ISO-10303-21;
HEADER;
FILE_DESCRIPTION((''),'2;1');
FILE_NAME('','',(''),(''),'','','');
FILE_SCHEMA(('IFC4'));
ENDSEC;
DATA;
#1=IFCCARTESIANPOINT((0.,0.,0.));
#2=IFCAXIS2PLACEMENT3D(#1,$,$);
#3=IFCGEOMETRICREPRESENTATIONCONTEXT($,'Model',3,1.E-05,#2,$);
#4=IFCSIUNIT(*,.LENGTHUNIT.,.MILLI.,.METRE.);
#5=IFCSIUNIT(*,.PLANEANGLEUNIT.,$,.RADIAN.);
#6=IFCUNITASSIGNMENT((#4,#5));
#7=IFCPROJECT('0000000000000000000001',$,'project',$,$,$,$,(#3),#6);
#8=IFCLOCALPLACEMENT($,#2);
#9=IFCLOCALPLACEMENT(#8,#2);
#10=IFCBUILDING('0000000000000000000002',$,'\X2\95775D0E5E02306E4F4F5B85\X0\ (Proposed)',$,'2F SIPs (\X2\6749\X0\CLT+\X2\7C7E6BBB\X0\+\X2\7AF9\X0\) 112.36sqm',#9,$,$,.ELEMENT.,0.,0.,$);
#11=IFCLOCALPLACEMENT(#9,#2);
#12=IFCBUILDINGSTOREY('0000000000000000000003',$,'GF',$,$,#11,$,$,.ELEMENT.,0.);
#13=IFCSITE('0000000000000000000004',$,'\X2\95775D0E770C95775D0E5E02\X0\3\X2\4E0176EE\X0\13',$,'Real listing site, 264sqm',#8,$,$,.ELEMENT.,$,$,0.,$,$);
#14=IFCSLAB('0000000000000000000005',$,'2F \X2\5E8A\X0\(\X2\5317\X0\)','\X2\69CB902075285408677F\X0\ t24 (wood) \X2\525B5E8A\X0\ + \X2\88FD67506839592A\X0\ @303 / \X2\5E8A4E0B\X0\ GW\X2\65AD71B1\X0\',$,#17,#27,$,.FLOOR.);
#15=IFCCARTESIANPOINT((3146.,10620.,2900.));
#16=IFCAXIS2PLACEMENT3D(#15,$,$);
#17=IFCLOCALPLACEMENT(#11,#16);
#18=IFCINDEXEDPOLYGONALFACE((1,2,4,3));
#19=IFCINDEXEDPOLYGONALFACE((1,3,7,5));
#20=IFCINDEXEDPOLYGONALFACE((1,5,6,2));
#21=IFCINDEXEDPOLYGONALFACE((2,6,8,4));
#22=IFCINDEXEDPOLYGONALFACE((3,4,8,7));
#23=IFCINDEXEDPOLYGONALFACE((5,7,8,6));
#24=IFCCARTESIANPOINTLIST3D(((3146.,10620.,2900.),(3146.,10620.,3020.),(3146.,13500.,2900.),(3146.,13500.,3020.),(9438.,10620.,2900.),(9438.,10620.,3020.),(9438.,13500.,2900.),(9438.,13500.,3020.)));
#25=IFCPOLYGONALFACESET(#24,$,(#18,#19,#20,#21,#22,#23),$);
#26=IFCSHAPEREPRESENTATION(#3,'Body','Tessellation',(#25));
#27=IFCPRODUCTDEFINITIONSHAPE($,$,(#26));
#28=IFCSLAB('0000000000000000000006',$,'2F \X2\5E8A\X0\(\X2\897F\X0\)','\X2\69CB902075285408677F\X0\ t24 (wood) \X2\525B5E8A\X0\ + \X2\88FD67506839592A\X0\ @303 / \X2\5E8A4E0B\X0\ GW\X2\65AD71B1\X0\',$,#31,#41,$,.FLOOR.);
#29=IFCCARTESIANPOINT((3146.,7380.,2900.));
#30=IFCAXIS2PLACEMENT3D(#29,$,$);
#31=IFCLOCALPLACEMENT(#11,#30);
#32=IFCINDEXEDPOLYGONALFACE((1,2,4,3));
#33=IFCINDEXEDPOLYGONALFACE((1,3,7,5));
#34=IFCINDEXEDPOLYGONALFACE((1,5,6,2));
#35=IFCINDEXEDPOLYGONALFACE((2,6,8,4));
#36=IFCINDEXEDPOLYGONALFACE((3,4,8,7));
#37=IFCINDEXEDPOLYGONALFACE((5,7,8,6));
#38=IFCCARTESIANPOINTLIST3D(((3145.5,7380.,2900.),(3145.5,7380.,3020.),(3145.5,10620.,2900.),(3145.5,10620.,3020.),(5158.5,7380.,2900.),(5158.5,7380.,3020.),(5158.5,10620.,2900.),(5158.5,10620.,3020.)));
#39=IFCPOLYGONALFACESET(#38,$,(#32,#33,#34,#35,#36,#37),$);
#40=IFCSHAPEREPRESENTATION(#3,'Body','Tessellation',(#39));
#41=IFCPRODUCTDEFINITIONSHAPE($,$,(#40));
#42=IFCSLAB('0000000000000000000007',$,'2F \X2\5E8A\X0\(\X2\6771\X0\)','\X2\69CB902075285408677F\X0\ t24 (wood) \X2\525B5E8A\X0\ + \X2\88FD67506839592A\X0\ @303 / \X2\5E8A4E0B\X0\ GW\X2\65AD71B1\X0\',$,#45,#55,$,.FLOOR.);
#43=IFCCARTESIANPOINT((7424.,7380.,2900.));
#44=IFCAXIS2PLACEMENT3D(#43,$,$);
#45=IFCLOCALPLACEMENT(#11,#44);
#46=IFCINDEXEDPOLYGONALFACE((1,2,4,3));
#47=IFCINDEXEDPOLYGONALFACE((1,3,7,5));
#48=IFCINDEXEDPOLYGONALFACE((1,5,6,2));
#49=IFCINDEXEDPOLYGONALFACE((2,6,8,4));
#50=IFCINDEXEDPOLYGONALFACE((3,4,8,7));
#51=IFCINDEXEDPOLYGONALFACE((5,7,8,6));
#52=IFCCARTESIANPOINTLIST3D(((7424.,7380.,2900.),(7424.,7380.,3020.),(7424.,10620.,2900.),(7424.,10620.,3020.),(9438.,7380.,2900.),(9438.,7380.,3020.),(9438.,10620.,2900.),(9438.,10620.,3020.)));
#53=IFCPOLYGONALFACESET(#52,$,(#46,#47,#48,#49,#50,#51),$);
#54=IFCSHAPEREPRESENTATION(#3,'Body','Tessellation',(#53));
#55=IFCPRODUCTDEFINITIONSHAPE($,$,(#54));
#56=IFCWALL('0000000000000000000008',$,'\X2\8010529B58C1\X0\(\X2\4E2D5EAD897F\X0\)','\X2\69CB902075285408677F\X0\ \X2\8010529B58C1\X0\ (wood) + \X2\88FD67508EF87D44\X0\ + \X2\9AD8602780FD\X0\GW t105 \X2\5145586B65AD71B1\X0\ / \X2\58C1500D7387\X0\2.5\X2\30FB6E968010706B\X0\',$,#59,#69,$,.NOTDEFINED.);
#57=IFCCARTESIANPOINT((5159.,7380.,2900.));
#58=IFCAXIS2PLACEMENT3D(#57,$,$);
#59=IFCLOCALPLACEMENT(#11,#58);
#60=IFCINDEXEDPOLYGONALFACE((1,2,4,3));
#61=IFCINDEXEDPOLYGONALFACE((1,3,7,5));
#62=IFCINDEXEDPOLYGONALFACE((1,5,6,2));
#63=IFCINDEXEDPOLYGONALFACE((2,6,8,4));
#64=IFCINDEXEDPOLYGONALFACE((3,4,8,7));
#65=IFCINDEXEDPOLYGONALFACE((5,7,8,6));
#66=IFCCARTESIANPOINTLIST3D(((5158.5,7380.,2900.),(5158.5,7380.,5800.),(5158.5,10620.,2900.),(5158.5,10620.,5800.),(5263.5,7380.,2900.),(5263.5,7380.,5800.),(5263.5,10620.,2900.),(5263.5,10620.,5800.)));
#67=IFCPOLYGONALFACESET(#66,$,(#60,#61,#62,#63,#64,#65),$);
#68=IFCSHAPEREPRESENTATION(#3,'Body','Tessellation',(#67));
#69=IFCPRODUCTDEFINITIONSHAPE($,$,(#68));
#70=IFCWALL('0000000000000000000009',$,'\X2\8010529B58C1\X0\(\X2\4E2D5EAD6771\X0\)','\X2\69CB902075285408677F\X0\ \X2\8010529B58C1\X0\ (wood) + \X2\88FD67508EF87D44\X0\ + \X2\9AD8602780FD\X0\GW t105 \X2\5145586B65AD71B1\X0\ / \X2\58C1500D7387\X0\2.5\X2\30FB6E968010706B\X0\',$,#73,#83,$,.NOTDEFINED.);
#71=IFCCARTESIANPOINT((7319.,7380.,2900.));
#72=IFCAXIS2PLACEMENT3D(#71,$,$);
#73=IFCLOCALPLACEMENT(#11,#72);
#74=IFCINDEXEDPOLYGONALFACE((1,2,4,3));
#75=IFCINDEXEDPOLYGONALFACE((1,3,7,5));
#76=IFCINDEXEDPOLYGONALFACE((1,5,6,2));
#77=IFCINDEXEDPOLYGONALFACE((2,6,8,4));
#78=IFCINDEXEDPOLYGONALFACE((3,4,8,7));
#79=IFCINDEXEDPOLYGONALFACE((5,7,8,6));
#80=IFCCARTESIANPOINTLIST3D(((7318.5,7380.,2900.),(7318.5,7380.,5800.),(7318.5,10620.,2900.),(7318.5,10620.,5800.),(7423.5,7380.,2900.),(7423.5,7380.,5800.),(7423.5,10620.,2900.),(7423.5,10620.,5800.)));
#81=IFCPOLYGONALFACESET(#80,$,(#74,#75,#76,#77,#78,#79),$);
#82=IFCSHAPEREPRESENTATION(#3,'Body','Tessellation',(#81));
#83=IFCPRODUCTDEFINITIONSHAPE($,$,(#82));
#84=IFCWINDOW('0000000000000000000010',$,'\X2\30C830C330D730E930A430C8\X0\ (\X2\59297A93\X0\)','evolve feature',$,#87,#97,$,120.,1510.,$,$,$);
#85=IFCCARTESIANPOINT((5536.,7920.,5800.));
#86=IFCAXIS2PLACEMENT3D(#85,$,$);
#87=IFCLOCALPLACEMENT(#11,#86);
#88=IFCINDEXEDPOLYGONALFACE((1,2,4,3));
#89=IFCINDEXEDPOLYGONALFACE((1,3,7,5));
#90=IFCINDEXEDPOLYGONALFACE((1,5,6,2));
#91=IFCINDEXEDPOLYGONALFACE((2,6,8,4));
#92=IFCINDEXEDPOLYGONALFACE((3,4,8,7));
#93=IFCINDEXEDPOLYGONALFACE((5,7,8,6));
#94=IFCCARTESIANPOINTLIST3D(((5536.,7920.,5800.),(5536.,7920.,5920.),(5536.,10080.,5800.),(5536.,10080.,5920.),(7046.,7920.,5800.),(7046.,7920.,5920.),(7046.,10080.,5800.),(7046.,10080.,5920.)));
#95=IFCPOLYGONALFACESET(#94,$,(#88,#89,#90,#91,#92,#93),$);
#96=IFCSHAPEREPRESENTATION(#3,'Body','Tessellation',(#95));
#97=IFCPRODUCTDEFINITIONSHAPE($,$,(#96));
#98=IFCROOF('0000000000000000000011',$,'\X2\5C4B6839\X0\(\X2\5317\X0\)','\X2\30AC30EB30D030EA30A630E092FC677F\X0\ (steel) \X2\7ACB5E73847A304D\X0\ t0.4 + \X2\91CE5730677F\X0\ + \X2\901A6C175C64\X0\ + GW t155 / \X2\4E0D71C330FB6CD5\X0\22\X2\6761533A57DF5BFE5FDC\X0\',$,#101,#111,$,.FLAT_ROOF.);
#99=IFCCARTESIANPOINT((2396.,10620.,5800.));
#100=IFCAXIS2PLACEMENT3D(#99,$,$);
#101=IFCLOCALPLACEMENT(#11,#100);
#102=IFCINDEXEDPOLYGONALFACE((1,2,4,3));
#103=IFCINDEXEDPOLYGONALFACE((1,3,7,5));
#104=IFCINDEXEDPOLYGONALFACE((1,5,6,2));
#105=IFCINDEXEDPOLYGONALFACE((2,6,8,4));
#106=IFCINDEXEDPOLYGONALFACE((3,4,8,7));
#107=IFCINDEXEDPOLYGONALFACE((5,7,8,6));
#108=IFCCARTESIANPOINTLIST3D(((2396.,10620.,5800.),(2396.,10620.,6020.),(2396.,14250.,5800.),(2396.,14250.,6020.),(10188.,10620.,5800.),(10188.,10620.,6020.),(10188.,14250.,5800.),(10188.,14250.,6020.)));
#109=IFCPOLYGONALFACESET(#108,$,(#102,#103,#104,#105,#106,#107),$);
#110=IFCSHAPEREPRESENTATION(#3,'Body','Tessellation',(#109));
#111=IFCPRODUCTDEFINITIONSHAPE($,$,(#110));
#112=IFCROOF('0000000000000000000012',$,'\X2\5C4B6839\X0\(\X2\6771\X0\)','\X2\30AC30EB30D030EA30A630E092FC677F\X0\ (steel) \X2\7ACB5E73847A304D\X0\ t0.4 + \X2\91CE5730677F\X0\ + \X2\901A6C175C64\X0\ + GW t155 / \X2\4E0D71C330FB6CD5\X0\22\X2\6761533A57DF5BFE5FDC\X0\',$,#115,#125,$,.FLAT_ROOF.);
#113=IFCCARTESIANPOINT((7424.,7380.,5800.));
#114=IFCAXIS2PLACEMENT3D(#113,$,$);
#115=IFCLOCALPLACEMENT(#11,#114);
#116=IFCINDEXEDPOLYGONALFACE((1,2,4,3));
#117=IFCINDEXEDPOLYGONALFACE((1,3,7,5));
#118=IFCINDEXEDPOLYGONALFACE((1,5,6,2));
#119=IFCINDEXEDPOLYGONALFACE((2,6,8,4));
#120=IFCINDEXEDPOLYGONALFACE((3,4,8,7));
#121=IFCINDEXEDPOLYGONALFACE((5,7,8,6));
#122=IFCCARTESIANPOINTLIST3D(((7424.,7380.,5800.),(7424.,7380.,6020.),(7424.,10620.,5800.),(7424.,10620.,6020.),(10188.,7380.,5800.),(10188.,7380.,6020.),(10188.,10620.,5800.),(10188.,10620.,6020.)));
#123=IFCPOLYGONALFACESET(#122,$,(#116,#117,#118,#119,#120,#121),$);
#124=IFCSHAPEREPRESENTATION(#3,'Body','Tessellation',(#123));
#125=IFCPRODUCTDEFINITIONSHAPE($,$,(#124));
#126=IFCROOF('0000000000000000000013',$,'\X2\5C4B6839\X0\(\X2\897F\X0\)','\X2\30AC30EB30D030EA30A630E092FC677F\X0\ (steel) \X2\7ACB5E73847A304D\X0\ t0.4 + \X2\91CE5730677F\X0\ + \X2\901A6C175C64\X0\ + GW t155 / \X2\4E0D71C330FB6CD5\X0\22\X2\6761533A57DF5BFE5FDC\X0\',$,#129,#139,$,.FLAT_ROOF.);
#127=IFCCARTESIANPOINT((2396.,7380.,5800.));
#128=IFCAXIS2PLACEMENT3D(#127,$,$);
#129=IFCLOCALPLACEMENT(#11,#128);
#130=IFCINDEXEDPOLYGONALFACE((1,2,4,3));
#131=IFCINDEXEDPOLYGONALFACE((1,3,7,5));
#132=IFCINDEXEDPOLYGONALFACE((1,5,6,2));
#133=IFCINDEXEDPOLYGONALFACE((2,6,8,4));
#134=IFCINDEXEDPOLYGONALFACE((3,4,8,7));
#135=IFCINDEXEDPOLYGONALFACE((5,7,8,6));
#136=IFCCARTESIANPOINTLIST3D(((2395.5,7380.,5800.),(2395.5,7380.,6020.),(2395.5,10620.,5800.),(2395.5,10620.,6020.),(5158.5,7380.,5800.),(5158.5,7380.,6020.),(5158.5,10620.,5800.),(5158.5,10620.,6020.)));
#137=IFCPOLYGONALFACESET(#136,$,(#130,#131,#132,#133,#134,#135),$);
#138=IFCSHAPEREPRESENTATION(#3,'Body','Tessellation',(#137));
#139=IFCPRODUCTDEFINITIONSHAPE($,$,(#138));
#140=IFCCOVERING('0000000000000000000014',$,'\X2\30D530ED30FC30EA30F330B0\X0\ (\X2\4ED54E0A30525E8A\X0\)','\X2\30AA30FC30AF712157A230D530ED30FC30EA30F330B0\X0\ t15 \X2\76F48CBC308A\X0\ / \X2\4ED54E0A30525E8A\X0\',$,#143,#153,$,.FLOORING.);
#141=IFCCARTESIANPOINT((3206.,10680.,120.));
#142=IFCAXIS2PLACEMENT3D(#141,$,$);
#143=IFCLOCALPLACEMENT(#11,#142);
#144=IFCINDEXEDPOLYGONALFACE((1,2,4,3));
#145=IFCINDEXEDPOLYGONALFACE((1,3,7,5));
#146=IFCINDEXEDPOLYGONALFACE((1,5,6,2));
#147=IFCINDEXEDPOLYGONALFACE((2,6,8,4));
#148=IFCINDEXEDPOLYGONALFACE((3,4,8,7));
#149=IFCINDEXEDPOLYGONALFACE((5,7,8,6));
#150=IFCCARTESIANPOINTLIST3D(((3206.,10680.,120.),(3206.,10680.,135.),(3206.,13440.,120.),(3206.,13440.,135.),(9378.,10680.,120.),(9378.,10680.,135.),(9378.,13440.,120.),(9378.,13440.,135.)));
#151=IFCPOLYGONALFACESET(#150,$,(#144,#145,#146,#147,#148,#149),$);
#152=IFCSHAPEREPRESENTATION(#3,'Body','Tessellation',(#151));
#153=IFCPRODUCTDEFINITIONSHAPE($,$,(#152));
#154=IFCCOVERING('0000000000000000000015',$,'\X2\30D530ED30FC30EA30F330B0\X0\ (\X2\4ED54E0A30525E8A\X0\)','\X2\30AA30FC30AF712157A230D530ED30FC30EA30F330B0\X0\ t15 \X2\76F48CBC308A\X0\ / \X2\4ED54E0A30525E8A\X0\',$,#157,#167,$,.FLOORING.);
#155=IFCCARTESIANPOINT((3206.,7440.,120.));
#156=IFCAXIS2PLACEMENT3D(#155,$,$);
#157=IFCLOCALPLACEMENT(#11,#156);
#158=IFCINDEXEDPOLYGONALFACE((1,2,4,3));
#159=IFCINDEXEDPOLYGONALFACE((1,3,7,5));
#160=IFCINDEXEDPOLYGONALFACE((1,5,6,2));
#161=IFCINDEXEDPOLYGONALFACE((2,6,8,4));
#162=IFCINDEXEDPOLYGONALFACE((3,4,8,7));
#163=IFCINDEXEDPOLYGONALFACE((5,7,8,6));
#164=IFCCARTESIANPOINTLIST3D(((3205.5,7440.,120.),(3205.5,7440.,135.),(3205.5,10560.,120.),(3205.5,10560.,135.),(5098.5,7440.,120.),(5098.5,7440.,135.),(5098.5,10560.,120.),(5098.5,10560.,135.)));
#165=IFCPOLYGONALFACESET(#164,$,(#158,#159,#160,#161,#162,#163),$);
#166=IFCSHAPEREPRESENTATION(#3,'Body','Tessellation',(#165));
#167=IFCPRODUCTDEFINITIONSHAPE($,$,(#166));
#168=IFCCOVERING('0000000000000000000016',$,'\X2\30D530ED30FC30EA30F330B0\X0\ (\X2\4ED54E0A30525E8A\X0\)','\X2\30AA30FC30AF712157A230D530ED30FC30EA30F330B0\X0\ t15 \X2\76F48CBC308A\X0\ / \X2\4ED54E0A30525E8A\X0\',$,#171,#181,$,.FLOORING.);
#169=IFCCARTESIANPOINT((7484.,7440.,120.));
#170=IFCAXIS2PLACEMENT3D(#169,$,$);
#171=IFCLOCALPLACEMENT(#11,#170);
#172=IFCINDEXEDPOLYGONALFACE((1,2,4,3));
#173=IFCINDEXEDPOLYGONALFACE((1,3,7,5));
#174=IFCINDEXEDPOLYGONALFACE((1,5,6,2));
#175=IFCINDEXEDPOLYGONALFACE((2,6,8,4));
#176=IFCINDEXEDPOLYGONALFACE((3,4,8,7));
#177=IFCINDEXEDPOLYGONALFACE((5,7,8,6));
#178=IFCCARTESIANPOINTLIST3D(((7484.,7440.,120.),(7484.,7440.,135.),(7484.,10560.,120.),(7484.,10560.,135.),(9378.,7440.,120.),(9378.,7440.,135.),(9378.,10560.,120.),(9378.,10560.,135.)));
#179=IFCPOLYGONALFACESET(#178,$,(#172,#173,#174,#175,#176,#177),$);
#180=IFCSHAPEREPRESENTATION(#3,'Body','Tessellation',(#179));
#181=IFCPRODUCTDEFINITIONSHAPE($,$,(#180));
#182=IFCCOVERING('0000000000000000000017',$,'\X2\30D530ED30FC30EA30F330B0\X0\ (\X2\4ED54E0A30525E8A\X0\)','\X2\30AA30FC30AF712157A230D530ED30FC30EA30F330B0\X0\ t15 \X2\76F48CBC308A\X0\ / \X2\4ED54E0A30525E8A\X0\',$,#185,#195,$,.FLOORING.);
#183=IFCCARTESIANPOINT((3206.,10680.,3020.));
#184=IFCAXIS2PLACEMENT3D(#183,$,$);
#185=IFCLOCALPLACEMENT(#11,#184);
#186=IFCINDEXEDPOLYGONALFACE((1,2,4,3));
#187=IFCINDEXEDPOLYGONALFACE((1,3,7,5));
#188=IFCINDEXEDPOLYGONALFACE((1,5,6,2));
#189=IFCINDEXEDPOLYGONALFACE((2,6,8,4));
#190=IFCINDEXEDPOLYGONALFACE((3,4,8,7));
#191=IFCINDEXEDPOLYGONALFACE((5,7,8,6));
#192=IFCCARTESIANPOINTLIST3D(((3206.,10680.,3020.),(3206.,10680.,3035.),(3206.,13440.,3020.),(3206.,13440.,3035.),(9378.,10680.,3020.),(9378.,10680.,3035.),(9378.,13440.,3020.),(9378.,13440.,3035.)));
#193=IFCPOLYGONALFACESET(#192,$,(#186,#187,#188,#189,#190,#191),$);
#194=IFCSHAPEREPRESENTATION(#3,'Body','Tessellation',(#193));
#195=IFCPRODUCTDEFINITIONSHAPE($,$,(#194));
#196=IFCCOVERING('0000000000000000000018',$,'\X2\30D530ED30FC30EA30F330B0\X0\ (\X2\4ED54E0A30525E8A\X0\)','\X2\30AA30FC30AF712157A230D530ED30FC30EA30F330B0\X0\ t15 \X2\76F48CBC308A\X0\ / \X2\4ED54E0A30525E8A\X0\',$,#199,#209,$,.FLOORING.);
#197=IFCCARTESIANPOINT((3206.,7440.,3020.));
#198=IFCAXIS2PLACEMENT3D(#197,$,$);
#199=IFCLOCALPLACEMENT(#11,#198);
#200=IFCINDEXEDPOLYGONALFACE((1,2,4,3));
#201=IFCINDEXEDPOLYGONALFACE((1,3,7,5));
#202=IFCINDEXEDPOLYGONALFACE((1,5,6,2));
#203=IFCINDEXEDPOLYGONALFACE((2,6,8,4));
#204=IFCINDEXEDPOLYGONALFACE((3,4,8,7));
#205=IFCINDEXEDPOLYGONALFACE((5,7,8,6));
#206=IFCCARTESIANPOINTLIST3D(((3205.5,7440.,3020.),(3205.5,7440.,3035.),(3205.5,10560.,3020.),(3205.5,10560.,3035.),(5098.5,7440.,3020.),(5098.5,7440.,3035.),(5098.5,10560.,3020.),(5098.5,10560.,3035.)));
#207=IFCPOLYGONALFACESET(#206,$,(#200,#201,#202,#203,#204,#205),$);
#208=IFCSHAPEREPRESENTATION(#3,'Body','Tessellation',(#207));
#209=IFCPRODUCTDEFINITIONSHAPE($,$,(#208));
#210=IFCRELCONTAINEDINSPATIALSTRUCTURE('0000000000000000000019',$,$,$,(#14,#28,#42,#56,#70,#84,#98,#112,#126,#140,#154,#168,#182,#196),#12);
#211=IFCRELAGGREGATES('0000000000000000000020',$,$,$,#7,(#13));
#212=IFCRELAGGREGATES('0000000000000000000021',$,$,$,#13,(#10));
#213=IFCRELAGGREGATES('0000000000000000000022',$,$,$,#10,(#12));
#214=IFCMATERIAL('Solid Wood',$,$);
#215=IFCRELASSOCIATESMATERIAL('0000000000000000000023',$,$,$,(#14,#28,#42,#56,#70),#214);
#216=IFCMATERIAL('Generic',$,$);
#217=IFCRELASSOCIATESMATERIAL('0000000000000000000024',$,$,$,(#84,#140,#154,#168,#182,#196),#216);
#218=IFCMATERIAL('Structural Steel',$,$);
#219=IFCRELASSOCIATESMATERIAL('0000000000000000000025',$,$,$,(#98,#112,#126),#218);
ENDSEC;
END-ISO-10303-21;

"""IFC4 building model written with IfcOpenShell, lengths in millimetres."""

from ifc_helpers import new_model, si_unit, frame, frame_2d, origin, place, context, project, spatial, rectangle, extrude, material, element, save


model = new_model("IFC4")

# Units and contexts
model_context = context("Model", 3, precision=1e-05, world=origin())
ifc_project = project(units=[si_unit("LENGTHUNIT", "METRE", prefix="MILLI"), si_unit("PLANEANGLEUNIT", "RADIAN")], contexts=[model_context])

# Site, building, storey
site_placement = place(None, origin())
site = spatial("IfcSite", under=ifc_project, at=site_placement, Name="長崎県長崎市3丁目13", ObjectType="Real listing site, 264sqm", CompositionType="ELEMENT", RefElevation=0.0)
building_placement = place(site_placement, origin())
building = spatial("IfcBuilding", under=site, at=building_placement, Name="長崎市の住宅 (Proposed)", ObjectType="2F SIPs (杉CLT+籾殻+竹) 112.36sqm", CompositionType="ELEMENT", ElevationOfRefHeight=0.0, ElevationOfTerrain=0.0)
storey_placement = place(building_placement, origin())
storey = spatial("IfcBuildingStorey", under=building, at=storey_placement, Name="GF", CompositionType="ELEMENT", Elevation=0.0)

# Slabs
ifc_material_1 = material(Name="Solid Wood")
slab_1_placement = place(storey_placement, frame((3146.0, 10620.0, 2900.0)))
element("IfcSlab", 1, at=slab_1_placement, inside=storey, material=ifc_material_1, Name="2F 床(北)", Description="構造用合板 t24 (wood) 剛床 + 製材根太 @303 / 床下 GW断熱", PredefinedType="FLOOR", context=model_context, shape_type="SweptSolid", body=[
    extrude(rectangle(XDim=6292.0, YDim=2880.0, at=frame_2d((3146.0, 1440.0))), frame((3146.0, 10620.0, 2900.0)), (0.0, 0.0, 1.0), 120.0),
])
slab_2_placement = place(storey_placement, frame((3146.0, 7380.0, 2900.0)))
element("IfcSlab", 2, at=slab_2_placement, inside=storey, material=ifc_material_1, Name="2F 床(西)", Description="構造用合板 t24 (wood) 剛床 + 製材根太 @303 / 床下 GW断熱", PredefinedType="FLOOR", context=model_context, shape_type="SweptSolid", body=[
    extrude(rectangle(XDim=2013.0, YDim=3240.0, at=frame_2d((1006.0, 1620.0))), frame((3146.0, 7380.0, 2900.0)), (0.0, 0.0, 1.0), 120.0),
])
slab_3_placement = place(storey_placement, frame((7424.0, 7380.0, 2900.0)))
element("IfcSlab", 3, at=slab_3_placement, inside=storey, material=ifc_material_1, Name="2F 床(東)", Description="構造用合板 t24 (wood) 剛床 + 製材根太 @303 / 床下 GW断熱", PredefinedType="FLOOR", context=model_context, shape_type="SweptSolid", body=[
    extrude(rectangle(XDim=2014.0, YDim=3240.0, at=frame_2d((1007.0, 1620.0))), frame((7424.0, 7380.0, 2900.0)), (0.0, 0.0, 1.0), 120.0),
])

# Walls
wall_1_placement = place(storey_placement, frame((5159.0, 7380.0, 2900.0)))
element("IfcWall", 4, at=wall_1_placement, inside=storey, material=ifc_material_1, Name="耐力壁(中庭西)", Description="構造用合板 耐力壁 (wood) + 製材軸組 + 高性能GW t105 充填断熱 / 壁倍率2.5・準耐火", PredefinedType="NOTDEFINED", context=model_context, shape_type="SweptSolid", body=[
    extrude(rectangle(XDim=105.0, YDim=3240.0, at=frame_2d((52.0, 1620.0))), frame((5159.0, 7380.0, 2900.0)), (0.0, 0.0, 1.0), 2900.0),
])
wall_2_placement = place(storey_placement, frame((7319.0, 7380.0, 2900.0)))
element("IfcWall", 5, at=wall_2_placement, inside=storey, material=ifc_material_1, Name="耐力壁(中庭東)", Description="構造用合板 耐力壁 (wood) + 製材軸組 + 高性能GW t105 充填断熱 / 壁倍率2.5・準耐火", PredefinedType="NOTDEFINED", context=model_context, shape_type="SweptSolid", body=[
    extrude(rectangle(XDim=105.0, YDim=3240.0, at=frame_2d((52.0, 1620.0))), frame((7319.0, 7380.0, 2900.0)), (0.0, 0.0, 1.0), 2900.0),
])

# Window
ifc_material_2 = material(Name="Generic")
window_1_placement = place(storey_placement, frame((5536.0, 7920.0, 5800.0)))
element("IfcWindow", 6, at=window_1_placement, inside=storey, material=ifc_material_2, Name="トップライト (天窓)", Description="evolve feature", OverallHeight=120.0, OverallWidth=1510.0, context=model_context, shape_type="SweptSolid", body=[
    extrude(rectangle(XDim=1510.0, YDim=2160.0, at=frame_2d((755.0, 1080.0))), frame((5536.0, 7920.0, 5800.0)), (0.0, 0.0, 1.0), 120.0),
])

# Roofs
ifc_material_3 = material(Name="Structural Steel")
roof_1_placement = place(storey_placement, frame((2396.0, 10620.0, 5800.0)))
element("IfcRoof", 7, at=roof_1_placement, inside=storey, material=ifc_material_3, Name="屋根(北)", Description="ガルバリウム鋼板 (steel) 立平葺き t0.4 + 野地板 + 通気層 + GW t155 / 不燃・法22条区域対応", PredefinedType="FLAT_ROOF", context=model_context, shape_type="SweptSolid", body=[
    extrude(rectangle(XDim=7792.0, YDim=3630.0, at=frame_2d((3896.0, 1815.0))), frame((2396.0, 10620.0, 5800.0)), (0.0, 0.0, 1.0), 220.0),
])
roof_2_placement = place(storey_placement, frame((7424.0, 7380.0, 5800.0)))
element("IfcRoof", 8, at=roof_2_placement, inside=storey, material=ifc_material_3, Name="屋根(東)", Description="ガルバリウム鋼板 (steel) 立平葺き t0.4 + 野地板 + 通気層 + GW t155 / 不燃・法22条区域対応", PredefinedType="FLAT_ROOF", context=model_context, shape_type="SweptSolid", body=[
    extrude(rectangle(XDim=2764.0, YDim=3240.0, at=frame_2d((1382.0, 1620.0))), frame((7424.0, 7380.0, 5800.0)), (0.0, 0.0, 1.0), 220.0),
])
roof_3_placement = place(storey_placement, frame((2396.0, 7380.0, 5800.0)))
element("IfcRoof", 9, at=roof_3_placement, inside=storey, material=ifc_material_3, Name="屋根(西)", Description="ガルバリウム鋼板 (steel) 立平葺き t0.4 + 野地板 + 通気層 + GW t155 / 不燃・法22条区域対応", PredefinedType="FLAT_ROOF", context=model_context, shape_type="SweptSolid", body=[
    extrude(rectangle(XDim=2763.0, YDim=3240.0, at=frame_2d((1381.0, 1620.0))), frame((2396.0, 7380.0, 5800.0)), (0.0, 0.0, 1.0), 220.0),
])

# Coverings
covering_1_placement = place(storey_placement, frame((3206.0, 10680.0, 120.0)))
element("IfcCovering", 10, at=covering_1_placement, inside=storey, material=ifc_material_2, Name="フローリング (仕上げ床)", Description="オーク無垢フローリング t15 直貼り / 仕上げ床", PredefinedType="FLOORING", context=model_context, shape_type="SweptSolid", body=[
    extrude(rectangle(XDim=6172.0, YDim=2760.0, at=frame_2d((3086.0, 1380.0))), frame((3206.0, 10680.0, 120.0)), (0.0, 0.0, 1.0), 15.0),
])
covering_2_placement = place(storey_placement, frame((3206.0, 7440.0, 120.0)))
element("IfcCovering", 11, at=covering_2_placement, inside=storey, material=ifc_material_2, Name="フローリング (仕上げ床)", Description="オーク無垢フローリング t15 直貼り / 仕上げ床", PredefinedType="FLOORING", context=model_context, shape_type="SweptSolid", body=[
    extrude(rectangle(XDim=1893.0, YDim=3120.0, at=frame_2d((946.0, 1560.0))), frame((3206.0, 7440.0, 120.0)), (0.0, 0.0, 1.0), 15.0),
])
covering_3_placement = place(storey_placement, frame((7484.0, 7440.0, 120.0)))
element("IfcCovering", 12, at=covering_3_placement, inside=storey, material=ifc_material_2, Name="フローリング (仕上げ床)", Description="オーク無垢フローリング t15 直貼り / 仕上げ床", PredefinedType="FLOORING", context=model_context, shape_type="SweptSolid", body=[
    extrude(rectangle(XDim=1894.0, YDim=3120.0, at=frame_2d((947.0, 1560.0))), frame((7484.0, 7440.0, 120.0)), (0.0, 0.0, 1.0), 15.0),
])
covering_4_placement = place(storey_placement, frame((3206.0, 10680.0, 3020.0)))
element("IfcCovering", 13, at=covering_4_placement, inside=storey, material=ifc_material_2, Name="フローリング (仕上げ床)", Description="オーク無垢フローリング t15 直貼り / 仕上げ床", PredefinedType="FLOORING", context=model_context, shape_type="SweptSolid", body=[
    extrude(rectangle(XDim=6172.0, YDim=2760.0, at=frame_2d((3086.0, 1380.0))), frame((3206.0, 10680.0, 3020.0)), (0.0, 0.0, 1.0), 15.0),
])
covering_5_placement = place(storey_placement, frame((3206.0, 7440.0, 3020.0)))
element("IfcCovering", 14, at=covering_5_placement, inside=storey, material=ifc_material_2, Name="フローリング (仕上げ床)", Description="オーク無垢フローリング t15 直貼り / 仕上げ床", PredefinedType="FLOORING", context=model_context, shape_type="SweptSolid", body=[
    extrude(rectangle(XDim=1893.0, YDim=3120.0, at=frame_2d((946.0, 1560.0))), frame((3206.0, 7440.0, 3020.0)), (0.0, 0.0, 1.0), 15.0),
])

save(model, "model.ifc")
